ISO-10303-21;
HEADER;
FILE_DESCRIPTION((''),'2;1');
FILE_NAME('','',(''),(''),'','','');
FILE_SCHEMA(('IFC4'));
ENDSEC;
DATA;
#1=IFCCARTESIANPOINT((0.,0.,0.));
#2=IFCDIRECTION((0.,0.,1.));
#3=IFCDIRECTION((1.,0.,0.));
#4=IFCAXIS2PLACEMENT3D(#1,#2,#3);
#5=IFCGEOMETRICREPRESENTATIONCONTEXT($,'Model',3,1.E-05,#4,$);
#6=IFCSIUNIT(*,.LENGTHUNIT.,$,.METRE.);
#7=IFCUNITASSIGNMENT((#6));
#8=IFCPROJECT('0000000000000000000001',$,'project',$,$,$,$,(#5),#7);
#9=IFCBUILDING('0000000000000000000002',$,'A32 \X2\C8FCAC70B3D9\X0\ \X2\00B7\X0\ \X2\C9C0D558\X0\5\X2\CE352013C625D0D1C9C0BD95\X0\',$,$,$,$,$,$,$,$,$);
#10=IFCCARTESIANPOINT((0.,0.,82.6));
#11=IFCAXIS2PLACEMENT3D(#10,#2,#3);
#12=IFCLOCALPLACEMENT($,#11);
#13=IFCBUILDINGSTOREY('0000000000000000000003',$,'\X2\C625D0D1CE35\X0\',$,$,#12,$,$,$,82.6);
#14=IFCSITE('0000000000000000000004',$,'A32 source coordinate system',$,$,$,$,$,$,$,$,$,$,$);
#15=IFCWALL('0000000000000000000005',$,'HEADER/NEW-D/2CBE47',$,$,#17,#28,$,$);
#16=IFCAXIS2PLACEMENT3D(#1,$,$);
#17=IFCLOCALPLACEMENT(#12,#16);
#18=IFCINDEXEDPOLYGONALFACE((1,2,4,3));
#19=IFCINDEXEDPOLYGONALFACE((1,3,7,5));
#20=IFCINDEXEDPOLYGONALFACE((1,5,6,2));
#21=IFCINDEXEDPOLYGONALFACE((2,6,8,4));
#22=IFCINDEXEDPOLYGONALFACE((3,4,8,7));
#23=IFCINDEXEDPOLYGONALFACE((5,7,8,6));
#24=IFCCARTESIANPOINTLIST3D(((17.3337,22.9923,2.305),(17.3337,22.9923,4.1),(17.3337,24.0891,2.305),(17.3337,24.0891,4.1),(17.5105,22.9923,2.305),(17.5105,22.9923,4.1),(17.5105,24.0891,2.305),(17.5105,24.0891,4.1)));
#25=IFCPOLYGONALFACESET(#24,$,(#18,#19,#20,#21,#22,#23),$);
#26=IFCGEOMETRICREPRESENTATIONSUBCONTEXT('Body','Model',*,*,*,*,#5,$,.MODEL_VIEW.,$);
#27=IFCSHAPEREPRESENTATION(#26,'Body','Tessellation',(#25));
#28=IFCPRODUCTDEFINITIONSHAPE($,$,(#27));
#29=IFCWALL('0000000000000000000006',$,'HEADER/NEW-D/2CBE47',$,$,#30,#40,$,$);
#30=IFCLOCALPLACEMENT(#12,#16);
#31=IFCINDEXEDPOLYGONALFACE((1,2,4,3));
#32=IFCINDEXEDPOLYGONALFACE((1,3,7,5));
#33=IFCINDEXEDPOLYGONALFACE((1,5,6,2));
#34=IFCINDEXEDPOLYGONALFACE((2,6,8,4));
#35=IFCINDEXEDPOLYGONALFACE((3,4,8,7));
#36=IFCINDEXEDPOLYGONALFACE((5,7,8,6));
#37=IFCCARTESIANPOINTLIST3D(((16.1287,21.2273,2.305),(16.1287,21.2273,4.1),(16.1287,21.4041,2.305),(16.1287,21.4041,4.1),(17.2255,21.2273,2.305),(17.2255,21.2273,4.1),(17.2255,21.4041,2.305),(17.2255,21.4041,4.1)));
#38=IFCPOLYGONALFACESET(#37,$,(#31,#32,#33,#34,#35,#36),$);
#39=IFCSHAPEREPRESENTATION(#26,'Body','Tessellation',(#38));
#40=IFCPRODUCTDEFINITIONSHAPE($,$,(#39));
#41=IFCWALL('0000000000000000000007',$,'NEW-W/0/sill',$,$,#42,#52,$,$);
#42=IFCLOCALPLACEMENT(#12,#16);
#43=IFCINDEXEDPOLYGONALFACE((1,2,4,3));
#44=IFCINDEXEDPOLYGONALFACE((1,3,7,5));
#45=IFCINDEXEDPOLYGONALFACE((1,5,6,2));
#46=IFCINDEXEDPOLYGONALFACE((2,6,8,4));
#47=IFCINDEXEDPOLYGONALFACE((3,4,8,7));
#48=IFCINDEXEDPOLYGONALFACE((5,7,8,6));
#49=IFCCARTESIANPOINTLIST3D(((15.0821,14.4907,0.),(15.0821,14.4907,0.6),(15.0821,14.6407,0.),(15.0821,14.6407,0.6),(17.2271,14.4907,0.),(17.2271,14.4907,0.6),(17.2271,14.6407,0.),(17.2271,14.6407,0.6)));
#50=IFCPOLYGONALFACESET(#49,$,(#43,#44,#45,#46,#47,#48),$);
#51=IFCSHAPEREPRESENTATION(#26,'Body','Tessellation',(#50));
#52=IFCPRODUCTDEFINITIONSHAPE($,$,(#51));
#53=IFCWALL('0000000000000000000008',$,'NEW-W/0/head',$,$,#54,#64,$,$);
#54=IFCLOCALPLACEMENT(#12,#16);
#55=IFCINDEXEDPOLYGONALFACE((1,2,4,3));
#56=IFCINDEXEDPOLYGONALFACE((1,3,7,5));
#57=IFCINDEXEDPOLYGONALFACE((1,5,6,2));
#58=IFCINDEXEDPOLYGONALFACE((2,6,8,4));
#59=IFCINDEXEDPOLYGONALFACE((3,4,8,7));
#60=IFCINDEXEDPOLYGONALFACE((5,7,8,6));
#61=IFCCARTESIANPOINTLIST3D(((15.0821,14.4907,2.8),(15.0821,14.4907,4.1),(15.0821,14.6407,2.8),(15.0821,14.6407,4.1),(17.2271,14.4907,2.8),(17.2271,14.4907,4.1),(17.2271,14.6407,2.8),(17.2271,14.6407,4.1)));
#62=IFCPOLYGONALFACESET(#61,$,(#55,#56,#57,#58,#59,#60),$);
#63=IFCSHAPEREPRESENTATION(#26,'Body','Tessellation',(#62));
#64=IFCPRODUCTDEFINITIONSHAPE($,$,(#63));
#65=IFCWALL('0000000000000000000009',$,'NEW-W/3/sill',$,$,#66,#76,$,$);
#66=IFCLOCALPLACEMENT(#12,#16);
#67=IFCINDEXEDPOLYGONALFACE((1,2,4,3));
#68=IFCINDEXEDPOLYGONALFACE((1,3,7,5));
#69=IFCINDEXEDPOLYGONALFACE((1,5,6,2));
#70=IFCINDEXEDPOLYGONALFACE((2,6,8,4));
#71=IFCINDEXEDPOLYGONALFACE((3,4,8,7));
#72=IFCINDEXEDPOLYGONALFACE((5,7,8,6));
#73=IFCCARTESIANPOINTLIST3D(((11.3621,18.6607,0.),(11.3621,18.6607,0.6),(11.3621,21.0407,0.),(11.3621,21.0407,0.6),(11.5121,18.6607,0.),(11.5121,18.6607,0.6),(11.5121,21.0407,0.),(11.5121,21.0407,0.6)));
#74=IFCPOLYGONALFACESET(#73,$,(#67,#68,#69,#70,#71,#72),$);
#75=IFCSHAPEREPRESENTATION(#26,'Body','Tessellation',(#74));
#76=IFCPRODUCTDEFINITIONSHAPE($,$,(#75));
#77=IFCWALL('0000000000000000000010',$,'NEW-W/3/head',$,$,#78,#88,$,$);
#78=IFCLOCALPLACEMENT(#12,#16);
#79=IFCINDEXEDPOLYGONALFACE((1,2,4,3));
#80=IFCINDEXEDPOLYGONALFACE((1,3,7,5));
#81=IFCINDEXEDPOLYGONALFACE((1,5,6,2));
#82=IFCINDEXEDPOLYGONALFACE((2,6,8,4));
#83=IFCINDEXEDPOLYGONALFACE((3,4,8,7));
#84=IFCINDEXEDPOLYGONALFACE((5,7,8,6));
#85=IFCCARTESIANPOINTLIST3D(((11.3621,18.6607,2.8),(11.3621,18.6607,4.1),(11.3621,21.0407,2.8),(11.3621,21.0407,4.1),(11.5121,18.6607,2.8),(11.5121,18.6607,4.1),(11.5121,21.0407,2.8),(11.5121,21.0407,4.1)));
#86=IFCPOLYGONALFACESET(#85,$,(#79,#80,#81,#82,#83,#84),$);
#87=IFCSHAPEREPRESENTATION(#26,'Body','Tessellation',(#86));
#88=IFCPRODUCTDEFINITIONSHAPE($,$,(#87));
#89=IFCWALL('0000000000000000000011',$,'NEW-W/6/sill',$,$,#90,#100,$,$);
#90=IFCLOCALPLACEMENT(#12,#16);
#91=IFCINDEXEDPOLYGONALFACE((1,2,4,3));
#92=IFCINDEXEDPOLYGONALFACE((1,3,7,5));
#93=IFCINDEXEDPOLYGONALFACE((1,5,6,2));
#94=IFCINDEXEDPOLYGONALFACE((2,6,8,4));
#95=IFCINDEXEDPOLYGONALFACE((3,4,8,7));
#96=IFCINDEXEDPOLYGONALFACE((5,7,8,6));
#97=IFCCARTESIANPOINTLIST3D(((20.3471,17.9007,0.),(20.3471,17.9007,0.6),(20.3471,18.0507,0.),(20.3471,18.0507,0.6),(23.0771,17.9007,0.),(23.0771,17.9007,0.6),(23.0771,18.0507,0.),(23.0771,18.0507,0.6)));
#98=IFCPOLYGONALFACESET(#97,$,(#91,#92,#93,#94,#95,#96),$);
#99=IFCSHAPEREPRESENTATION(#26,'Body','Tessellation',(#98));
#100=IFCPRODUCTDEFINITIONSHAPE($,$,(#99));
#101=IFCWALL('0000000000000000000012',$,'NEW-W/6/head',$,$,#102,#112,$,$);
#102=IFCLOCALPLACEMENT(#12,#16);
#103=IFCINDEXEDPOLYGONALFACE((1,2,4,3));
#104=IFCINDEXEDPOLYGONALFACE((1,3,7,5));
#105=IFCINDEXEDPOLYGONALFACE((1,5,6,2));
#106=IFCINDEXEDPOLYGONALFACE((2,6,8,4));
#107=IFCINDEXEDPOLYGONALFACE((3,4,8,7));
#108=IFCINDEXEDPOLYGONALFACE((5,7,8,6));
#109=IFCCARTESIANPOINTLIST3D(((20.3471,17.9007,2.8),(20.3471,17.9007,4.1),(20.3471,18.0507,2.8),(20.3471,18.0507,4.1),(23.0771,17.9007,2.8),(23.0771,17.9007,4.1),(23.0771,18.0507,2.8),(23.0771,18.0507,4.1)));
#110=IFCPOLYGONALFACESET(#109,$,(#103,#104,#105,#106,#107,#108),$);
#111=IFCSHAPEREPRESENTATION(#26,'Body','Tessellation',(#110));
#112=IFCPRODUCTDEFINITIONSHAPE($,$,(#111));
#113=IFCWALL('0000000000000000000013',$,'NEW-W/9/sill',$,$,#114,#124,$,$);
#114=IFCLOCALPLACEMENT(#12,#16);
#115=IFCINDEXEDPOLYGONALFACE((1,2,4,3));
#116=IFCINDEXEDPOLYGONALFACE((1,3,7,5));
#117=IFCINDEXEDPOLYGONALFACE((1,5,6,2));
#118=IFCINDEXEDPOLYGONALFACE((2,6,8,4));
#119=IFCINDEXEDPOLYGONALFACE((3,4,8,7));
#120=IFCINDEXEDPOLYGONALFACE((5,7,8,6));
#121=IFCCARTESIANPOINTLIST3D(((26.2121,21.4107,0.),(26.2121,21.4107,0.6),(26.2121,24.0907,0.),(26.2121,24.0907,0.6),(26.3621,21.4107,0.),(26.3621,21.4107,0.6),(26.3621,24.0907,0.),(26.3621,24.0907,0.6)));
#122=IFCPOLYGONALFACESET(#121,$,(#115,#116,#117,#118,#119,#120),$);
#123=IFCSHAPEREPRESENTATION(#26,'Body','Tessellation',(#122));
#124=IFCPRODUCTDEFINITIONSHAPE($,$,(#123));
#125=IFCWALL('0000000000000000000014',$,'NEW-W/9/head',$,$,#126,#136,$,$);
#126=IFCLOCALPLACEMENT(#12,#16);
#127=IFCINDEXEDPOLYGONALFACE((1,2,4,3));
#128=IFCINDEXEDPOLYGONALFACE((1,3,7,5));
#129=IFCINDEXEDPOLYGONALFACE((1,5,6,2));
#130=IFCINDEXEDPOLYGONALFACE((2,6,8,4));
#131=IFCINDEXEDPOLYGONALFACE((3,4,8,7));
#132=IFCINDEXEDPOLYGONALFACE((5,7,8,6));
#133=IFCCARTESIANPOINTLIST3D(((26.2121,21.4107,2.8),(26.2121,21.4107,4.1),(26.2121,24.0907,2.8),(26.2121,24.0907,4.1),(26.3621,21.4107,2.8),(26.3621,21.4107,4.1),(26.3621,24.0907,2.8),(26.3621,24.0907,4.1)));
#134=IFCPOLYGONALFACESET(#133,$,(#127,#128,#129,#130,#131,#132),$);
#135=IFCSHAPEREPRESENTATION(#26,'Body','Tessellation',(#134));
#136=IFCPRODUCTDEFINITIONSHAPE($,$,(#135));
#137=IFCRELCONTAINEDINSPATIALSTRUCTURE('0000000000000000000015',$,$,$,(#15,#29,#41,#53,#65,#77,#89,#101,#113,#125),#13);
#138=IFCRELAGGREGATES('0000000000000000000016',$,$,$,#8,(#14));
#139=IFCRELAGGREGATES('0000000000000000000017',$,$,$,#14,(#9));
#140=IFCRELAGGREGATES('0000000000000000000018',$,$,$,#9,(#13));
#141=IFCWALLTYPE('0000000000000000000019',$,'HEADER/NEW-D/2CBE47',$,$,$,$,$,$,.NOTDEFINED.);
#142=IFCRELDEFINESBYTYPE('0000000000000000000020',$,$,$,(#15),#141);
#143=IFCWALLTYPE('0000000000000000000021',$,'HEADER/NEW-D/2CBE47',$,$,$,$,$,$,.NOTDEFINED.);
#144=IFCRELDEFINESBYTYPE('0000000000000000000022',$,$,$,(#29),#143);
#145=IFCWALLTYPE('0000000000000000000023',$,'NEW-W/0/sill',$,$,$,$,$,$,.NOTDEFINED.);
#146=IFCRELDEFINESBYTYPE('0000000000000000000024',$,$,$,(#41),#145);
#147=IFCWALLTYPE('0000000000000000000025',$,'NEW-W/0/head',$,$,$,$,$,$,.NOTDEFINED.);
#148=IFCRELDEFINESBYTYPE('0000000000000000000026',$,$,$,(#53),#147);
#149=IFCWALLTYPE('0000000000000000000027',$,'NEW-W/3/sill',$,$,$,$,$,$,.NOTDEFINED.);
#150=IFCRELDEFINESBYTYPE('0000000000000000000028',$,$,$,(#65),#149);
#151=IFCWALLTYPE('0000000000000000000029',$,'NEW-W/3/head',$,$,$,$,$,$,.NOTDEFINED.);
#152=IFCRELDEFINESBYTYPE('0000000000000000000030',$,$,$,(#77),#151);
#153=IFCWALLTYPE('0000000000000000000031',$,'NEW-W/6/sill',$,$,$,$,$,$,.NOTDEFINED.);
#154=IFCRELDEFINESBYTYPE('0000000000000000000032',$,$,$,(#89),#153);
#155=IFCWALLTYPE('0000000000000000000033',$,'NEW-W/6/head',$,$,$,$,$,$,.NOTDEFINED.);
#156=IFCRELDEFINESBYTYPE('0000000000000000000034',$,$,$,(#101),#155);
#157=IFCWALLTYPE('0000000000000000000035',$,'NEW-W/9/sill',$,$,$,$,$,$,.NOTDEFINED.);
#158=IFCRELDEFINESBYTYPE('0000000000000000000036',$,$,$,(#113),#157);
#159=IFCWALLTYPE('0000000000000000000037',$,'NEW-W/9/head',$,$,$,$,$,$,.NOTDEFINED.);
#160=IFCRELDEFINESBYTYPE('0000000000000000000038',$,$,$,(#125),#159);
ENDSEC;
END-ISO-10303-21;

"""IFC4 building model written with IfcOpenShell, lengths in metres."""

from ifc_helpers import new_model, si_unit, frame, origin, origin_with_axes, place, context, subcontext, project, spatial, polyline, outline, extrude, source, transform, mapped, type_object, type_shapes, element, save


model = new_model("IFC4")

# Units and contexts
model_context = context("Model", 3, precision=1e-05, world=origin_with_axes())
body_context = subcontext(model_context, "Body", "Model", "MODEL_VIEW")
ifc_project = project(units=[si_unit("LENGTHUNIT", "METRE")], contexts=[model_context])

# Site, building, storey
storey_placement = place(None, frame((0.0, 0.0, 82.6), z_axis=(0.0, 0.0, 1.0), x_axis=(1.0, 0.0, 0.0)))
site = spatial("IfcSite", under=ifc_project, Name="A32 source coordinate system")
building = spatial("IfcBuilding", under=site, Name="A32 주거동 · 지하5층–옥탑지붕")
storey = spatial("IfcBuildingStorey", under=building, at=storey_placement, Name="옥탑층", Elevation=82.6)

# Walls
wall_type_1 = type_object("IfcWallType", Name="HEADER/NEW-D/2CBE47", PredefinedType="NOTDEFINED")
shared_shape_1 = source(origin(), body_context, "Body", "SweptSolid", [
    extrude(outline(polyline([(17.3337, 22.9923), (17.3337, 24.0891), (17.5105, 24.0891), (17.5105, 22.9923), (17.3337, 22.9923)])), frame((0.0, 0.0, 2.305)), (0.0, 0.0, 1.0), 1.795),
])
type_shapes(wall_type_1, [shared_shape_1])
wall_1_placement = place(storey_placement, origin_with_axes())
element("IfcWall", 1, at=wall_1_placement, inside=storey, type_object=wall_type_1, Name="HEADER/NEW-D/2CBE47", context=body_context, shape_type="MappedRepresentation", body=[
    mapped(shared_shape_1, transform((0.0, 0.0, 0.0), scale=1.0)),
])
wall_type_2 = type_object("IfcWallType", Name="HEADER/NEW-D/2CBE47", PredefinedType="NOTDEFINED")
shared_shape_2 = source(origin(), body_context, "Body", "SweptSolid", [
    extrude(outline(polyline([(16.1287, 21.2273), (16.1287, 21.4041), (17.2255, 21.4041), (17.2255, 21.2273), (16.1287, 21.2273)])), frame((0.0, 0.0, 2.305)), (0.0, 0.0, 1.0), 1.795),
])
type_shapes(wall_type_2, [shared_shape_2])
wall_2_placement = place(storey_placement, origin_with_axes())
element("IfcWall", 2, at=wall_2_placement, inside=storey, type_object=wall_type_2, Name="HEADER/NEW-D/2CBE47", context=body_context, shape_type="MappedRepresentation", body=[
    mapped(shared_shape_2, transform((0.0, 0.0, 0.0), scale=1.0)),
])
wall_type_3 = type_object("IfcWallType", Name="NEW-W/0/sill", PredefinedType="NOTDEFINED")
shared_shape_3 = source(origin(), body_context, "Body", "SweptSolid", [
    extrude(outline(polyline([(15.0821, 14.4907), (15.0821, 14.6407), (17.2271, 14.6407), (17.2271, 14.4907), (15.0821, 14.4907)])), origin(), (0.0, 0.0, 1.0), 0.6),
])
type_shapes(wall_type_3, [shared_shape_3])
wall_3_placement = place(storey_placement, origin_with_axes())
element("IfcWall", 3, at=wall_3_placement, inside=storey, type_object=wall_type_3, Name="NEW-W/0/sill", context=body_context, shape_type="MappedRepresentation", body=[
    mapped(shared_shape_3, transform((0.0, 0.0, 0.0), scale=1.0)),
])
wall_type_4 = type_object("IfcWallType", Name="NEW-W/0/head", PredefinedType="NOTDEFINED")
shared_shape_4 = source(origin(), body_context, "Body", "SweptSolid", [
    extrude(outline(polyline([(15.0821, 14.4907), (15.0821, 14.6407), (17.2271, 14.6407), (17.2271, 14.4907), (15.0821, 14.4907)])), frame((0.0, 0.0, 2.8)), (0.0, 0.0, 1.0), 1.3),
])
type_shapes(wall_type_4, [shared_shape_4])
wall_4_placement = place(storey_placement, origin_with_axes())
element("IfcWall", 4, at=wall_4_placement, inside=storey, type_object=wall_type_4, Name="NEW-W/0/head", context=body_context, shape_type="MappedRepresentation", body=[
    mapped(shared_shape_4, transform((0.0, 0.0, 0.0), scale=1.0)),
])
wall_type_5 = type_object("IfcWallType", Name="NEW-W/3/sill", PredefinedType="NOTDEFINED")
shared_shape_5 = source(origin(), body_context, "Body", "SweptSolid", [
    extrude(outline(polyline([(11.3621, 18.6607), (11.3621, 21.0407), (11.5121, 21.0407), (11.5121, 18.6607), (11.3621, 18.6607)])), origin(), (0.0, 0.0, 1.0), 0.6),
])
type_shapes(wall_type_5, [shared_shape_5])
wall_5_placement = place(storey_placement, origin_with_axes())
element("IfcWall", 5, at=wall_5_placement, inside=storey, type_object=wall_type_5, Name="NEW-W/3/sill", context=body_context, shape_type="MappedRepresentation", body=[
    mapped(shared_shape_5, transform((0.0, 0.0, 0.0), scale=1.0)),
])
wall_type_6 = type_object("IfcWallType", Name="NEW-W/3/head", PredefinedType="NOTDEFINED")
shared_shape_6 = source(origin(), body_context, "Body", "SweptSolid", [
    extrude(outline(polyline([(11.3621, 18.6607), (11.3621, 21.0407), (11.5121, 21.0407), (11.5121, 18.6607), (11.3621, 18.6607)])), frame((0.0, 0.0, 2.8)), (0.0, 0.0, 1.0), 1.3),
])
type_shapes(wall_type_6, [shared_shape_6])
wall_6_placement = place(storey_placement, origin_with_axes())
element("IfcWall", 6, at=wall_6_placement, inside=storey, type_object=wall_type_6, Name="NEW-W/3/head", context=body_context, shape_type="MappedRepresentation", body=[
    mapped(shared_shape_6, transform((0.0, 0.0, 0.0), scale=1.0)),
])
wall_type_7 = type_object("IfcWallType", Name="NEW-W/6/sill", PredefinedType="NOTDEFINED")
shared_shape_7 = source(origin(), body_context, "Body", "SweptSolid", [
    extrude(outline(polyline([(20.3471, 17.9007), (20.3471, 18.0507), (23.0771, 18.0507), (23.0771, 17.9007), (20.3471, 17.9007)])), origin(), (0.0, 0.0, 1.0), 0.6),
])
type_shapes(wall_type_7, [shared_shape_7])
wall_7_placement = place(storey_placement, origin_with_axes())
element("IfcWall", 7, at=wall_7_placement, inside=storey, type_object=wall_type_7, Name="NEW-W/6/sill", context=body_context, shape_type="MappedRepresentation", body=[
    mapped(shared_shape_7, transform((0.0, 0.0, 0.0), scale=1.0)),
])
wall_type_8 = type_object("IfcWallType", Name="NEW-W/6/head", PredefinedType="NOTDEFINED")
shared_shape_8 = source(origin(), body_context, "Body", "SweptSolid", [
    extrude(outline(polyline([(20.3471, 17.9007), (20.3471, 18.0507), (23.0771, 18.0507), (23.0771, 17.9007), (20.3471, 17.9007)])), frame((0.0, 0.0, 2.8)), (0.0, 0.0, 1.0), 1.3),
])
type_shapes(wall_type_8, [shared_shape_8])
wall_8_placement = place(storey_placement, origin_with_axes())
element("IfcWall", 8, at=wall_8_placement, inside=storey, type_object=wall_type_8, Name="NEW-W/6/head", context=body_context, shape_type="MappedRepresentation", body=[
    mapped(shared_shape_8, transform((0.0, 0.0, 0.0), scale=1.0)),
])
wall_type_9 = type_object("IfcWallType", Name="NEW-W/9/sill", PredefinedType="NOTDEFINED")
shared_shape_9 = source(origin(), body_context, "Body", "SweptSolid", [
    extrude(outline(polyline([(26.2121, 21.4107), (26.2121, 24.0907), (26.3621, 24.0907), (26.3621, 21.4107), (26.2121, 21.4107)])), origin(), (0.0, 0.0, 1.0), 0.6),
])
type_shapes(wall_type_9, [shared_shape_9])
wall_9_placement = place(storey_placement, origin_with_axes())
element("IfcWall", 9, at=wall_9_placement, inside=storey, type_object=wall_type_9, Name="NEW-W/9/sill", context=body_context, shape_type="MappedRepresentation", body=[
    mapped(shared_shape_9, transform((0.0, 0.0, 0.0), scale=1.0)),
])
wall_type_10 = type_object("IfcWallType", Name="NEW-W/9/head", PredefinedType="NOTDEFINED")
shared_shape_10 = source(origin(), body_context, "Body", "SweptSolid", [
    extrude(outline(polyline([(26.2121, 21.4107), (26.2121, 24.0907), (26.3621, 24.0907), (26.3621, 21.4107), (26.2121, 21.4107)])), frame((0.0, 0.0, 2.8)), (0.0, 0.0, 1.0), 1.3),
])
type_shapes(wall_type_10, [shared_shape_10])
wall_10_placement = place(storey_placement, origin_with_axes())
element("IfcWall", 10, at=wall_10_placement, inside=storey, type_object=wall_type_10, Name="NEW-W/9/head", context=body_context, shape_type="MappedRepresentation", body=[
    mapped(shared_shape_10, transform((0.0, 0.0, 0.0), scale=1.0)),
])

save(model, "model.ifc")
